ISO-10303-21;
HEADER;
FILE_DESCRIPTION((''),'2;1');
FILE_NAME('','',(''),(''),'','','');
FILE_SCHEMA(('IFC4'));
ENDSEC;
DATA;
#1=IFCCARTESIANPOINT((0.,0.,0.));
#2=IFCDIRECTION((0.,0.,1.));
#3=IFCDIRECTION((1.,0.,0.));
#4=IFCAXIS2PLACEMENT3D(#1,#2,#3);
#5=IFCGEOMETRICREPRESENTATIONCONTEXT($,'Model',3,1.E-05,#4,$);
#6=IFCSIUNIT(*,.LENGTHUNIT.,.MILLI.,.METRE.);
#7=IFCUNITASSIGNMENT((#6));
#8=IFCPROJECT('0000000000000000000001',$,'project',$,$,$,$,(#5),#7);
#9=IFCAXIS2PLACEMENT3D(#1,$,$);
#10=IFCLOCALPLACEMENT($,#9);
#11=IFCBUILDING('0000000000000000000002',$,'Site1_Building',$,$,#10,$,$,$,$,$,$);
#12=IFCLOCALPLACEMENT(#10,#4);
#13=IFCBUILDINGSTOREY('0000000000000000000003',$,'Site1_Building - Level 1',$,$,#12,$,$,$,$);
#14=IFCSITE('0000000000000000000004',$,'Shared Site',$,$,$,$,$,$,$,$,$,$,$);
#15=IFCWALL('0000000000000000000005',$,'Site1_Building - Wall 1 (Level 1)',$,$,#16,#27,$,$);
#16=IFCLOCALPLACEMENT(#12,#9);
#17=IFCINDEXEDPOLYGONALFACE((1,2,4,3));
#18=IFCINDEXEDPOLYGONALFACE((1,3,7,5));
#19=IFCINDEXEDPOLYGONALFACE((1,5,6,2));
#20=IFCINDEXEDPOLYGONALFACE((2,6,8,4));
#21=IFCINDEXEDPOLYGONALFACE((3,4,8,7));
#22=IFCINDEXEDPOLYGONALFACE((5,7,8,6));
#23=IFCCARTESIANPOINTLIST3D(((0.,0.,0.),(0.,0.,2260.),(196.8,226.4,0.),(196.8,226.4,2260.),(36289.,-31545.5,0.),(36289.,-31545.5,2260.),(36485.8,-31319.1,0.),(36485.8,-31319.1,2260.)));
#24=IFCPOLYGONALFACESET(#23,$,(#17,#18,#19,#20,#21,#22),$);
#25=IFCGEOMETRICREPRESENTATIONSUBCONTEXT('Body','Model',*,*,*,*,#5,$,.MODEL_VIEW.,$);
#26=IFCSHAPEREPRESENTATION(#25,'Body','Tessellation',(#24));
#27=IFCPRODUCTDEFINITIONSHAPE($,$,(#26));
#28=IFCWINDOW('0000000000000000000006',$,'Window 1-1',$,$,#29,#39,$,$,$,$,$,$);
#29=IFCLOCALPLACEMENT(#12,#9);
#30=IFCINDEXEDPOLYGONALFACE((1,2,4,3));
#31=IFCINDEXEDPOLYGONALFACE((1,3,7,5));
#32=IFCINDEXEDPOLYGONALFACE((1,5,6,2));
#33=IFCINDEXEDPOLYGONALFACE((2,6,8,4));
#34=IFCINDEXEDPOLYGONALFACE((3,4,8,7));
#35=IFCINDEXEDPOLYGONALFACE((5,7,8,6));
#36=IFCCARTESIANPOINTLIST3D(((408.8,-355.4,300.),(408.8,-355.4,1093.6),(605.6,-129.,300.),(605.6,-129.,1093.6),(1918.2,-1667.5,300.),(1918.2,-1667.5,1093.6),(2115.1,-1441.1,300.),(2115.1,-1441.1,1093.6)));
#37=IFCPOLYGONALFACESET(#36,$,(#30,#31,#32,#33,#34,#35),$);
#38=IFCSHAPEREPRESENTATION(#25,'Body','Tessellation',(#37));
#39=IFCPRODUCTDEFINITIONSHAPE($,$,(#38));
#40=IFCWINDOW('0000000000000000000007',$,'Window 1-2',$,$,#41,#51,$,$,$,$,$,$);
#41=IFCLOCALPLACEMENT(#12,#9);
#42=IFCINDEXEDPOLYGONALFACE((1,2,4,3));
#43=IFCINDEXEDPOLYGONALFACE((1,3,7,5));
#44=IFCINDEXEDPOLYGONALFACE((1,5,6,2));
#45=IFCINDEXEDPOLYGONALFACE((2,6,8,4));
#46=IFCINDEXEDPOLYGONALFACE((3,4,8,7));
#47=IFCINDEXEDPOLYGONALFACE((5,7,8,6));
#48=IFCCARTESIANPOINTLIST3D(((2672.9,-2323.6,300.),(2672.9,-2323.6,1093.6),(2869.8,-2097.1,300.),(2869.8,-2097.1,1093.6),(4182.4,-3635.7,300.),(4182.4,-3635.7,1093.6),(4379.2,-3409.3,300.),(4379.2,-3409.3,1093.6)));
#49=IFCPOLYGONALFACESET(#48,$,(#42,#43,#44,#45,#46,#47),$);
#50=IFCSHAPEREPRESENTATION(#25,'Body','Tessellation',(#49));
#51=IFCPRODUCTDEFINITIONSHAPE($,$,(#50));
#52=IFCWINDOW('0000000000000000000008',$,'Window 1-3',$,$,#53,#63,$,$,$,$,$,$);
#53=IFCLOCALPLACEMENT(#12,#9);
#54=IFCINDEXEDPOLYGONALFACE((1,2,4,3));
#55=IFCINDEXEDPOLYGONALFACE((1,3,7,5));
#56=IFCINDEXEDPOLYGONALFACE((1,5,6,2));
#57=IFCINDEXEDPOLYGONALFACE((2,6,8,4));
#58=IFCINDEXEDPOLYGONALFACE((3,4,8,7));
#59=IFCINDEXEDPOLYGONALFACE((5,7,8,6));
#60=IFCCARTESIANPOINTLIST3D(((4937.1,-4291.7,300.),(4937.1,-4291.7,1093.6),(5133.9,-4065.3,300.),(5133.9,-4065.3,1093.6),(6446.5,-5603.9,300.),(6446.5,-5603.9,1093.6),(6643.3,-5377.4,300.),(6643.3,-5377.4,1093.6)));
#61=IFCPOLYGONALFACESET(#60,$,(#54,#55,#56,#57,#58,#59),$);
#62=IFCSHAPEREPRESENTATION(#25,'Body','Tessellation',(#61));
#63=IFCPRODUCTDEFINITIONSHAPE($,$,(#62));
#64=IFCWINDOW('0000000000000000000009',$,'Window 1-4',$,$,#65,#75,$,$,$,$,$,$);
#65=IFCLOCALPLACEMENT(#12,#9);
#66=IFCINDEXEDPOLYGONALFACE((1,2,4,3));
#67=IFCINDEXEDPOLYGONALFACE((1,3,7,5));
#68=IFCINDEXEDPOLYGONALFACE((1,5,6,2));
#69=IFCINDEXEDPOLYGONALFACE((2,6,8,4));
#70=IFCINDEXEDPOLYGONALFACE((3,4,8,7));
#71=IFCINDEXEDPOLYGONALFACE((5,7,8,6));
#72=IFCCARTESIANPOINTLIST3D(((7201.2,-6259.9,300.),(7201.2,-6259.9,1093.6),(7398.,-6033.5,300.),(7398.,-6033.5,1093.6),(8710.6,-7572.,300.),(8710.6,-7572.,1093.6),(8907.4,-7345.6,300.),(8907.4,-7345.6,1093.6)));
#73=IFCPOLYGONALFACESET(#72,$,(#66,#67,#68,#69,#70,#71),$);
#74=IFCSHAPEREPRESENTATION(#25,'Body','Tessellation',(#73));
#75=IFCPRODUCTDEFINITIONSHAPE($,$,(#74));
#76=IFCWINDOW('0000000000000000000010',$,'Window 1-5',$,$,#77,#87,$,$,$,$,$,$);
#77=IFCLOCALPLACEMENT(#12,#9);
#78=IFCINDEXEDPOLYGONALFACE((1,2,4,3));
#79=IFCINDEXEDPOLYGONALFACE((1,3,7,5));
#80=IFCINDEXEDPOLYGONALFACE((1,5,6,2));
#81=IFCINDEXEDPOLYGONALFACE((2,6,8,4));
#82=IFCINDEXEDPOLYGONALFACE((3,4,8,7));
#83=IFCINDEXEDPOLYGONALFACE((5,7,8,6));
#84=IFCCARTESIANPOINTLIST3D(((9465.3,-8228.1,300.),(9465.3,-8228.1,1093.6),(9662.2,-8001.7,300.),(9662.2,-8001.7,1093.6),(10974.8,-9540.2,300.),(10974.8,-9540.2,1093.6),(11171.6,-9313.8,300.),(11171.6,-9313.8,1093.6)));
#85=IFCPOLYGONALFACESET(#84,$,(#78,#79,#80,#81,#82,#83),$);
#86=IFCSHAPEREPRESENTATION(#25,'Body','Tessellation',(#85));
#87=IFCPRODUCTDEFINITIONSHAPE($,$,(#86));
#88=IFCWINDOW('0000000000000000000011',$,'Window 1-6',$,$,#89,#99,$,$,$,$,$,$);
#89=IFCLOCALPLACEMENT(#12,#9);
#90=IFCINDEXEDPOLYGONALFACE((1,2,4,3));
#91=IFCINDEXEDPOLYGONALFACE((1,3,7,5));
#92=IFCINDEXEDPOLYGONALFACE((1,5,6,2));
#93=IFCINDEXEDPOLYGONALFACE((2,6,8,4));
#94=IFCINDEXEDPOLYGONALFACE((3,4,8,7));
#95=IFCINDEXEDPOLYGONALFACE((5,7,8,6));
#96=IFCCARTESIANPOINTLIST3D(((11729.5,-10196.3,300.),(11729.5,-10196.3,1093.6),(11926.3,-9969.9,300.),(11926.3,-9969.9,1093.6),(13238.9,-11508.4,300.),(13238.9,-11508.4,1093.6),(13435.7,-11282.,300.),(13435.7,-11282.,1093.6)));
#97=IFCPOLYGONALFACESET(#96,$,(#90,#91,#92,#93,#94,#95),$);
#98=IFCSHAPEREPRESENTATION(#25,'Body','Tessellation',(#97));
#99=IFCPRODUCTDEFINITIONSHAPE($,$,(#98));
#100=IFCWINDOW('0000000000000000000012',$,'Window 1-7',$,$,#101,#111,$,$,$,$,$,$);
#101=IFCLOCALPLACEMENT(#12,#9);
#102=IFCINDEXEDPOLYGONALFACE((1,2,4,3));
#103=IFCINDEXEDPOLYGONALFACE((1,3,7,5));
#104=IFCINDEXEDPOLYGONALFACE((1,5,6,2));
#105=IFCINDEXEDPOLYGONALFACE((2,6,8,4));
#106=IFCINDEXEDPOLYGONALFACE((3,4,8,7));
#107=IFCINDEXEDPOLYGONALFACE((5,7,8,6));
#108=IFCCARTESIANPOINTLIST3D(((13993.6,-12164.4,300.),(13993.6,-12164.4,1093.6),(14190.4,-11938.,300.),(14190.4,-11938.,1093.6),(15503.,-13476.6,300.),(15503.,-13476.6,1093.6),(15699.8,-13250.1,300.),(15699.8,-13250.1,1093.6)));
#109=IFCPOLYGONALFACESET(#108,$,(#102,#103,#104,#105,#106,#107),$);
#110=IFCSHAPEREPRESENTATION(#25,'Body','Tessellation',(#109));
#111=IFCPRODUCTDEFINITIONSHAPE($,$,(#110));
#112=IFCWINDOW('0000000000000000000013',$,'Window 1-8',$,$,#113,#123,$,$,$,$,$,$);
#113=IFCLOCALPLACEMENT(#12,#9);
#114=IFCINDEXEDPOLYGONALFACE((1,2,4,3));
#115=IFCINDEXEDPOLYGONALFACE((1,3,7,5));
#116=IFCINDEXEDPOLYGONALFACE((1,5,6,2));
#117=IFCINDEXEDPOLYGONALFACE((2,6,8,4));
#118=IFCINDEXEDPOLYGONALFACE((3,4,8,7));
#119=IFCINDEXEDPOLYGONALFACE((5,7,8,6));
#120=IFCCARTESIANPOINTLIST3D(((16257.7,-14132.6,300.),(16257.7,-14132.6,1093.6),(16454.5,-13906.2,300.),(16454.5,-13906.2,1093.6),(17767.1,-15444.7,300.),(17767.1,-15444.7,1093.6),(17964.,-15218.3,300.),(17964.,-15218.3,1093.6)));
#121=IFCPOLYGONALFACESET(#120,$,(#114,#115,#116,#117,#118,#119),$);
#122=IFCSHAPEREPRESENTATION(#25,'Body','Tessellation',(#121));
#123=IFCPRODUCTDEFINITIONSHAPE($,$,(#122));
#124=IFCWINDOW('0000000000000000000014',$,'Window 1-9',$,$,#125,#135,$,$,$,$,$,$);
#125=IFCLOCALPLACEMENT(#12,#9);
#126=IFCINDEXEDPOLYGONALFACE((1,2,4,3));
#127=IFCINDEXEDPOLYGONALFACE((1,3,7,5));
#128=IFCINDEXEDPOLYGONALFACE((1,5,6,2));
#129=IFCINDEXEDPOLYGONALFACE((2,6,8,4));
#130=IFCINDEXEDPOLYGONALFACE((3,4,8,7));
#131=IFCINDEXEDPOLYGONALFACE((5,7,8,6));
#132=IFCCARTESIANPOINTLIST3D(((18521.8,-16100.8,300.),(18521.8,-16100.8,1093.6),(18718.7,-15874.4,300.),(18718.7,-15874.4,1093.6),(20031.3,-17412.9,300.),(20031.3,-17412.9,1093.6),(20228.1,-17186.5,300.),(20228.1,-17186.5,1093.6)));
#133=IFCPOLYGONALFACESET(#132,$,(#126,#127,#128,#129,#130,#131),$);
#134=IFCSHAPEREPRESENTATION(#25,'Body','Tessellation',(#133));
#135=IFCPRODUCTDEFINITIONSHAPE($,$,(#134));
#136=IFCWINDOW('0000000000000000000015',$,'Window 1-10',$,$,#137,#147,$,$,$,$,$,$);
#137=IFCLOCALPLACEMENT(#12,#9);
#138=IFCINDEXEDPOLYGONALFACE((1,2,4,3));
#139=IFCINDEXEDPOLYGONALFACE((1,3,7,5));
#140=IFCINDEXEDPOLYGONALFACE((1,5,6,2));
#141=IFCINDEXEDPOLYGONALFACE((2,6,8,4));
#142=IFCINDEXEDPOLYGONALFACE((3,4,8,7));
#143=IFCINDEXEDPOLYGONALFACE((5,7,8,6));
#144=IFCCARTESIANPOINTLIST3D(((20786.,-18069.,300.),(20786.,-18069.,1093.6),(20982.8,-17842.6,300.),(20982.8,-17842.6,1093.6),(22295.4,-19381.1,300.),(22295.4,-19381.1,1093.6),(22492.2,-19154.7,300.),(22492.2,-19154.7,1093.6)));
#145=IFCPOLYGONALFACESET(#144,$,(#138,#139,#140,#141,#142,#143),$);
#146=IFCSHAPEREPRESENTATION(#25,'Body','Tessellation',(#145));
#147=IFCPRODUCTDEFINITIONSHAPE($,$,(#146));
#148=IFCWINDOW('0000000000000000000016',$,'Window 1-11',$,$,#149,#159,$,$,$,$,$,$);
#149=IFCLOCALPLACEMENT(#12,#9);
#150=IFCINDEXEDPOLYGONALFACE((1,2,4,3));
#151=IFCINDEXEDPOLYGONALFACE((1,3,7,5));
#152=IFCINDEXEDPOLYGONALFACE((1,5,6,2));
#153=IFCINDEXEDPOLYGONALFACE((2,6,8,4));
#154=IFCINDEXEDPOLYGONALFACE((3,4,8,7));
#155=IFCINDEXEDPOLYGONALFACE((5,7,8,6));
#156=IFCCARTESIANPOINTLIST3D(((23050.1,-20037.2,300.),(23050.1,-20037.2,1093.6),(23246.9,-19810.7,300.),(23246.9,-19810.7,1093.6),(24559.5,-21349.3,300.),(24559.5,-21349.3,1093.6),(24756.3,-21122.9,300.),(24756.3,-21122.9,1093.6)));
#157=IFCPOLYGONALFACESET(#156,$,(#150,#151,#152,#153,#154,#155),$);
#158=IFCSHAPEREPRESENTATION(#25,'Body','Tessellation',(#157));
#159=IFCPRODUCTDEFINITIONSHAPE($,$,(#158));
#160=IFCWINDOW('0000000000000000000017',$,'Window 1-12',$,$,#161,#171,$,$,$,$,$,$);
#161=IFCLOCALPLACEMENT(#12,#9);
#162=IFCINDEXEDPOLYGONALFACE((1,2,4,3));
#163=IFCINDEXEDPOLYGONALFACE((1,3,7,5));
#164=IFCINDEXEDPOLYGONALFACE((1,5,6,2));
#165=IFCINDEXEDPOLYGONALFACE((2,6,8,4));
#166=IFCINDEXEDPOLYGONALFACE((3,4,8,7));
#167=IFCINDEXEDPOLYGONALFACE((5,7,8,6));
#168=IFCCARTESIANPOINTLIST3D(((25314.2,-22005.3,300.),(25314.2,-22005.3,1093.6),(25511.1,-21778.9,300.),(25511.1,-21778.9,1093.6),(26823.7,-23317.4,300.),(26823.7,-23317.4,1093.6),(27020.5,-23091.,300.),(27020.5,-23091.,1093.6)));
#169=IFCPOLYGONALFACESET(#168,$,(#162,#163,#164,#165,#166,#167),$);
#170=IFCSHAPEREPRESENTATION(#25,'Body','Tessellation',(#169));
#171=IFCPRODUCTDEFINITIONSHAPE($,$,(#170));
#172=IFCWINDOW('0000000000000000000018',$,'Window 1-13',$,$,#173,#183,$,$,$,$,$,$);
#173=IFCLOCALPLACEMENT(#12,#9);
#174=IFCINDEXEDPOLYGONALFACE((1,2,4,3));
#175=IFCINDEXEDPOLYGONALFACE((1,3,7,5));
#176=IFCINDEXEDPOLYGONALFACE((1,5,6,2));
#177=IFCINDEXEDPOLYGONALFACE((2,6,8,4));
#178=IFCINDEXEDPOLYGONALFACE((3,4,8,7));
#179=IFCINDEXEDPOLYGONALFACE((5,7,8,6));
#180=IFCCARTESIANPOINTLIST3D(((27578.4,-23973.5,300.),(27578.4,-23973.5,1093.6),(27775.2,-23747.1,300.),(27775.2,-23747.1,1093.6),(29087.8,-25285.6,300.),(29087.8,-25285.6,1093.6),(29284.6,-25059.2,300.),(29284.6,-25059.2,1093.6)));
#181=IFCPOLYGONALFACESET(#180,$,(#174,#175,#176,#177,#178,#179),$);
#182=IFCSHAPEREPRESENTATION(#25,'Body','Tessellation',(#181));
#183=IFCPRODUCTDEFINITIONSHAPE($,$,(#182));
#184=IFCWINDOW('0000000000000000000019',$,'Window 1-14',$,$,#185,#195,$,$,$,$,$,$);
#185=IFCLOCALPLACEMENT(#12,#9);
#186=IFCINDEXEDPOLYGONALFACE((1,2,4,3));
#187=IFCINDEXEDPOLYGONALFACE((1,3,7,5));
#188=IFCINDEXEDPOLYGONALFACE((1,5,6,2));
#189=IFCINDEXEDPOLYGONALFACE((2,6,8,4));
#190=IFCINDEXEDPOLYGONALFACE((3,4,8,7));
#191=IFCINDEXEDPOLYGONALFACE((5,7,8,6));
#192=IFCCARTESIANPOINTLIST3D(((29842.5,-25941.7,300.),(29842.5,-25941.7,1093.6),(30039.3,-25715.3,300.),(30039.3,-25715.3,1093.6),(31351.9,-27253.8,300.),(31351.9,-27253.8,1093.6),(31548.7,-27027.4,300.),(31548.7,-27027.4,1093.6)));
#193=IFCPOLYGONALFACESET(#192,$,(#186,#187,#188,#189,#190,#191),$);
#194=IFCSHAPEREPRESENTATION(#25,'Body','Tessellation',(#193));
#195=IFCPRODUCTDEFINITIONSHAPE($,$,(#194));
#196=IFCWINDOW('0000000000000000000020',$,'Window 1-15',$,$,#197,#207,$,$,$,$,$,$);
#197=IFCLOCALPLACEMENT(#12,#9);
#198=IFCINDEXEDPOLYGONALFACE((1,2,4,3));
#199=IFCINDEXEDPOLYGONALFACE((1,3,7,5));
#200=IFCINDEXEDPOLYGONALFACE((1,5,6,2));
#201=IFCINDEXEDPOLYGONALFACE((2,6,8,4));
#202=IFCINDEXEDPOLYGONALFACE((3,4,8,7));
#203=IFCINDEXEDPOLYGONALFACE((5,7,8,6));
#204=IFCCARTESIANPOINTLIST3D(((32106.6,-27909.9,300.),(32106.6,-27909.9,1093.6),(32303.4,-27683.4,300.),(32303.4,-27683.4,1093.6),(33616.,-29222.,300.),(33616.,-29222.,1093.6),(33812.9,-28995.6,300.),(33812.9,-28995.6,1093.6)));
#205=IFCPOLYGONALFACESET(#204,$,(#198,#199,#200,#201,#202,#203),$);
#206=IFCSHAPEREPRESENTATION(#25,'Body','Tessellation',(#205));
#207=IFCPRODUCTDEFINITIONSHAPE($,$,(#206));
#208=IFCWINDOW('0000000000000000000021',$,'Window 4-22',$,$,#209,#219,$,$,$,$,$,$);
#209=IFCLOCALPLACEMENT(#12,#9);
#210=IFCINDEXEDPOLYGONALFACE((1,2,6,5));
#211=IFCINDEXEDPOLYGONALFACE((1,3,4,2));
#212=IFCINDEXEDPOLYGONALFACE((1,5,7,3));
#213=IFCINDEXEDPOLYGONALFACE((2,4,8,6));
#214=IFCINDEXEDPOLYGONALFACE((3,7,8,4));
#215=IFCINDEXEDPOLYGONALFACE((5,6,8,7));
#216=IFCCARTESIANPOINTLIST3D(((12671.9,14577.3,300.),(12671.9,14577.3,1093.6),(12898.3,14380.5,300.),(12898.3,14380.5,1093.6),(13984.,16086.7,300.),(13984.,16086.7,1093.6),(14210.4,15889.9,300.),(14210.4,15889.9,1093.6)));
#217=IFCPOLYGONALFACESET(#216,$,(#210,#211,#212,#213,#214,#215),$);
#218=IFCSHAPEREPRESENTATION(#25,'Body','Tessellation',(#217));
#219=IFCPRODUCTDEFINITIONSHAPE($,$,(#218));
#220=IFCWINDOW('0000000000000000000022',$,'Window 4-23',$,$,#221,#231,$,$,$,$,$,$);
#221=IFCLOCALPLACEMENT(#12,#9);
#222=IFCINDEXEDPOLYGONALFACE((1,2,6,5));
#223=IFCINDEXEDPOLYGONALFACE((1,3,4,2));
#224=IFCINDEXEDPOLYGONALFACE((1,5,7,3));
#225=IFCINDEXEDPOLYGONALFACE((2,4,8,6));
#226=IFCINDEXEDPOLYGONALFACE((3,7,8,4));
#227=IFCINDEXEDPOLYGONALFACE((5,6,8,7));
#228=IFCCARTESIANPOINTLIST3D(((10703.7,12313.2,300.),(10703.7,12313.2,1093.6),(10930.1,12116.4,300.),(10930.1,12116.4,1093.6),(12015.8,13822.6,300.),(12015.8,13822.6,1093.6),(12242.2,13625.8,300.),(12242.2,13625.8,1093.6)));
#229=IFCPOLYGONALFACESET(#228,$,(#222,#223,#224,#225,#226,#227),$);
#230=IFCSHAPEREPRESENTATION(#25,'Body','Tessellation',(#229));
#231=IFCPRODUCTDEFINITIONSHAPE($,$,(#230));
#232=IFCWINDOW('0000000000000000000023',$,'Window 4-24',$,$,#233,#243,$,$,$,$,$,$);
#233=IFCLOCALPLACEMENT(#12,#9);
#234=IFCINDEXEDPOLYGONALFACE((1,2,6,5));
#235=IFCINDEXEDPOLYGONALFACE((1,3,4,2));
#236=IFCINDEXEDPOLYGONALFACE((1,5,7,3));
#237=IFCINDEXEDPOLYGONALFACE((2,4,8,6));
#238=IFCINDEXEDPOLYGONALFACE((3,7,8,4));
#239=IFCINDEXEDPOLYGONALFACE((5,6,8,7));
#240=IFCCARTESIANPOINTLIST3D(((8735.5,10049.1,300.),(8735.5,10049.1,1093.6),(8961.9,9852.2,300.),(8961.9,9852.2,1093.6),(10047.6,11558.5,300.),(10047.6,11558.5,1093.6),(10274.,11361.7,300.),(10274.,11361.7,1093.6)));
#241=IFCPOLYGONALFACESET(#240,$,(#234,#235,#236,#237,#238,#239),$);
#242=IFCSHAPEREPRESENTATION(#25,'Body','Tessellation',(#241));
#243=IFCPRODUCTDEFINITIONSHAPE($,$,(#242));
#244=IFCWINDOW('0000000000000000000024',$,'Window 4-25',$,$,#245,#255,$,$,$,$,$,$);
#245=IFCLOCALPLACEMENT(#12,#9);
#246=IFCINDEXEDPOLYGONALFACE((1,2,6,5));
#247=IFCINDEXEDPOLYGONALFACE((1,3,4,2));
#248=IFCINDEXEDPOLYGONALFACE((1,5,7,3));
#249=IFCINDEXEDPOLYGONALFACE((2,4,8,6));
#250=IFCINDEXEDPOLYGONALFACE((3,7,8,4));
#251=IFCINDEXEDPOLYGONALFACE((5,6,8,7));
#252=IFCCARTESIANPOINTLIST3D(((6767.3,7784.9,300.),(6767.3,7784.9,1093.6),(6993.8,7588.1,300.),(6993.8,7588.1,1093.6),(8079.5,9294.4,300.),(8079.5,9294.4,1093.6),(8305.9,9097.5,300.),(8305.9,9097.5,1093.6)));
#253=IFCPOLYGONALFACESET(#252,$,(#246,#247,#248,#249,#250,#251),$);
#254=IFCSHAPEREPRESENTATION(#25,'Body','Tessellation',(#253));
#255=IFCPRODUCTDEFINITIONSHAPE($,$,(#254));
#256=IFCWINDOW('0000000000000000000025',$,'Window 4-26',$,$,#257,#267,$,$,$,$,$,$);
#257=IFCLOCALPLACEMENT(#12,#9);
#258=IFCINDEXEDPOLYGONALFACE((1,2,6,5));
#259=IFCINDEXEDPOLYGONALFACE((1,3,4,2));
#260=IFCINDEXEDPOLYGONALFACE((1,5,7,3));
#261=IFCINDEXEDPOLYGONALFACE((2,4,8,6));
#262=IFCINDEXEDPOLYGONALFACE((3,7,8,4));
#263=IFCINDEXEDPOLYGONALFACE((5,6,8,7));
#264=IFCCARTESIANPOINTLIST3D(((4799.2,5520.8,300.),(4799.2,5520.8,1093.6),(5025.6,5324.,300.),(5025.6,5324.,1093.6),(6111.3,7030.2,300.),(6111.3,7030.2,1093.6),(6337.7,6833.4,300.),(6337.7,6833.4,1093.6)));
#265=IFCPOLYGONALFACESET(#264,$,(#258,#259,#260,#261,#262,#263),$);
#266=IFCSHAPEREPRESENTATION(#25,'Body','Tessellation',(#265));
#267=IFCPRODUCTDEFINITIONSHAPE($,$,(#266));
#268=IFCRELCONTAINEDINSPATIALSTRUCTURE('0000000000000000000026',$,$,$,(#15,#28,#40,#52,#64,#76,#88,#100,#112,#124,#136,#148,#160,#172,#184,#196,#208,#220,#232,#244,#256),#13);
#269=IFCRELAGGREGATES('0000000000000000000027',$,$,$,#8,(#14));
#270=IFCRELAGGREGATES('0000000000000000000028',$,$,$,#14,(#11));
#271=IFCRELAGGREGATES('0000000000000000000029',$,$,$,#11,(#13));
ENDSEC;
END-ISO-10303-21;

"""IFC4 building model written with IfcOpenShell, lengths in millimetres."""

from ifc_helpers import new_model, si_unit, frame, origin, origin_with_axes, place, context, subcontext, project, spatial, indexed_curve, outline, extrude, element, save


model = new_model("IFC4")

# Units and contexts
model_context = context("Model", 3, precision=1e-05, world=origin_with_axes())
body_context = subcontext(model_context, "Body", "Model", "MODEL_VIEW")
ifc_project = project(units=[si_unit("LENGTHUNIT", "METRE", prefix="MILLI")], contexts=[model_context])

# Site, building, storey
site = spatial("IfcSite", under=ifc_project, Name="Shared Site")
building_placement = place(None, origin())
building = spatial("IfcBuilding", under=site, at=building_placement, Name="Site1_Building")
storey_placement = place(building_placement, origin_with_axes())
storey = spatial("IfcBuildingStorey", under=building, at=storey_placement, Name="Site1_Building - Level 1")

# Wall
wall_placement = place(storey_placement, frame((0.0, 0.0, 0.0), z_axis=(0.0, 0.0, 1.0), x_axis=(0.75471, -0.656059, 0.0)))
element("IfcWall", 1, at=wall_placement, inside=storey, Name="Site1_Building - Wall 1 (Level 1)", context=body_context, shape_type="SweptSolid", body=[
    extrude(outline(indexed_curve([(0.0, 0.0), (0.0, 300.0), (48083.4, 300.0), (48083.4, 0.0), (0.0, 0.0)], self_intersect=False)), origin_with_axes(), (0.0, 0.0, 1.0), 2260.0),
])

# Windows
for number, where, z_axis, x_axis, name in (
    (2, (408.8, -355.4, 300.0), (0.0, 0.0, 1.0), (0.75471, -0.656059, 0.0), "Window 1-1"),
    (3, (2672.9, -2323.6, 300.0), (0.0, 0.0, 1.0), (0.75471, -0.656059, 0.0), "Window 1-2"),
    (4, (4937.1, -4291.7, 300.0), (0.0, 0.0, 1.0), (0.75471, -0.656059, 0.0), "Window 1-3"),
    (5, (7201.2, -6259.9, 300.0), (0.0, 0.0, 1.0), (0.75471, -0.656059, 0.0), "Window 1-4"),
    (6, (9465.3, -8228.1, 300.0), (0.0, 0.0, 1.0), (0.75471, -0.656059, 0.0), "Window 1-5"),
    (7, (11729.5, -10196.3, 300.0), (0.0, 0.0, 1.0), (0.75471, -0.656059, 0.0), "Window 1-6"),
    (8, (13993.6, -12164.4, 300.0), (0.0, 0.0, 1.0), (0.75471, -0.656059, 0.0), "Window 1-7"),
    (9, (16257.7, -14132.6, 300.0), (0.0, 0.0, 1.0), (0.75471, -0.656059, 0.0), "Window 1-8"),
    (10, (18521.8, -16100.8, 300.0), (0.0, 0.0, 1.0), (0.75471, -0.656059, 0.0), "Window 1-9"),
    (11, (20786.0, -18069.0, 300.0), (0.0, 0.0, 1.0), (0.75471, -0.656059, 0.0), "Window 1-10"),
    (12, (23050.1, -20037.2, 300.0), (0.0, 0.0, 1.0), (0.75471, -0.656059, 0.0), "Window 1-11"),
    (13, (25314.2, -22005.3, 300.0), (0.0, 0.0, 1.0), (0.75471, -0.656059, 0.0), "Window 1-12"),
    (14, (27578.4, -23973.5, 300.0), (0.0, 0.0, 1.0), (0.75471, -0.656059, 0.0), "Window 1-13"),
    (15, (29842.5, -25941.7, 300.0), (0.0, 0.0, 1.0), (0.75471, -0.656059, 0.0), "Window 1-14"),
    (16, (32106.6, -27909.9, 300.0), (0.0, 0.0, 1.0), (0.75471, -0.656059, 0.0), "Window 1-15"),
    (17, (13984.0, 16086.7, 300.0), (0.0, 0.0, 1.0), (-0.656059, -0.75471, 0.0), "Window 4-22"),
    (18, (12015.8, 13822.6, 300.0), (0.0, 0.0, 1.0), (-0.656059, -0.75471, 0.0), "Window 4-23"),
    (19, (10047.6, 11558.5, 300.0), (0.0, 0.0, 1.0), (-0.656059, -0.75471, 0.0), "Window 4-24"),
    (20, (8079.5, 9294.4, 300.0), (0.0, 0.0, 1.0), (-0.656059, -0.75471, 0.0), "Window 4-25"),
    (21, (6111.3, 7030.2, 300.0), (0.0, 0.0, 1.0), (-0.656059, -0.75471, 0.0), "Window 4-26"),
):
    element("IfcWindow", number, at=place(storey_placement, frame(where, z_axis=z_axis, x_axis=x_axis)), inside=storey, Name=name, context=body_context, shape_type="SweptSolid", body=[
        extrude(outline(indexed_curve([(0.0, 0.0), (0.0, 300.0), (2000.0, 300.0), (2000.0, 0.0), (0.0, 0.0)], self_intersect=False)), origin_with_axes(), (0.0, 0.0, 1.0), 793.6),
    ])

save(model, "model.ifc")
